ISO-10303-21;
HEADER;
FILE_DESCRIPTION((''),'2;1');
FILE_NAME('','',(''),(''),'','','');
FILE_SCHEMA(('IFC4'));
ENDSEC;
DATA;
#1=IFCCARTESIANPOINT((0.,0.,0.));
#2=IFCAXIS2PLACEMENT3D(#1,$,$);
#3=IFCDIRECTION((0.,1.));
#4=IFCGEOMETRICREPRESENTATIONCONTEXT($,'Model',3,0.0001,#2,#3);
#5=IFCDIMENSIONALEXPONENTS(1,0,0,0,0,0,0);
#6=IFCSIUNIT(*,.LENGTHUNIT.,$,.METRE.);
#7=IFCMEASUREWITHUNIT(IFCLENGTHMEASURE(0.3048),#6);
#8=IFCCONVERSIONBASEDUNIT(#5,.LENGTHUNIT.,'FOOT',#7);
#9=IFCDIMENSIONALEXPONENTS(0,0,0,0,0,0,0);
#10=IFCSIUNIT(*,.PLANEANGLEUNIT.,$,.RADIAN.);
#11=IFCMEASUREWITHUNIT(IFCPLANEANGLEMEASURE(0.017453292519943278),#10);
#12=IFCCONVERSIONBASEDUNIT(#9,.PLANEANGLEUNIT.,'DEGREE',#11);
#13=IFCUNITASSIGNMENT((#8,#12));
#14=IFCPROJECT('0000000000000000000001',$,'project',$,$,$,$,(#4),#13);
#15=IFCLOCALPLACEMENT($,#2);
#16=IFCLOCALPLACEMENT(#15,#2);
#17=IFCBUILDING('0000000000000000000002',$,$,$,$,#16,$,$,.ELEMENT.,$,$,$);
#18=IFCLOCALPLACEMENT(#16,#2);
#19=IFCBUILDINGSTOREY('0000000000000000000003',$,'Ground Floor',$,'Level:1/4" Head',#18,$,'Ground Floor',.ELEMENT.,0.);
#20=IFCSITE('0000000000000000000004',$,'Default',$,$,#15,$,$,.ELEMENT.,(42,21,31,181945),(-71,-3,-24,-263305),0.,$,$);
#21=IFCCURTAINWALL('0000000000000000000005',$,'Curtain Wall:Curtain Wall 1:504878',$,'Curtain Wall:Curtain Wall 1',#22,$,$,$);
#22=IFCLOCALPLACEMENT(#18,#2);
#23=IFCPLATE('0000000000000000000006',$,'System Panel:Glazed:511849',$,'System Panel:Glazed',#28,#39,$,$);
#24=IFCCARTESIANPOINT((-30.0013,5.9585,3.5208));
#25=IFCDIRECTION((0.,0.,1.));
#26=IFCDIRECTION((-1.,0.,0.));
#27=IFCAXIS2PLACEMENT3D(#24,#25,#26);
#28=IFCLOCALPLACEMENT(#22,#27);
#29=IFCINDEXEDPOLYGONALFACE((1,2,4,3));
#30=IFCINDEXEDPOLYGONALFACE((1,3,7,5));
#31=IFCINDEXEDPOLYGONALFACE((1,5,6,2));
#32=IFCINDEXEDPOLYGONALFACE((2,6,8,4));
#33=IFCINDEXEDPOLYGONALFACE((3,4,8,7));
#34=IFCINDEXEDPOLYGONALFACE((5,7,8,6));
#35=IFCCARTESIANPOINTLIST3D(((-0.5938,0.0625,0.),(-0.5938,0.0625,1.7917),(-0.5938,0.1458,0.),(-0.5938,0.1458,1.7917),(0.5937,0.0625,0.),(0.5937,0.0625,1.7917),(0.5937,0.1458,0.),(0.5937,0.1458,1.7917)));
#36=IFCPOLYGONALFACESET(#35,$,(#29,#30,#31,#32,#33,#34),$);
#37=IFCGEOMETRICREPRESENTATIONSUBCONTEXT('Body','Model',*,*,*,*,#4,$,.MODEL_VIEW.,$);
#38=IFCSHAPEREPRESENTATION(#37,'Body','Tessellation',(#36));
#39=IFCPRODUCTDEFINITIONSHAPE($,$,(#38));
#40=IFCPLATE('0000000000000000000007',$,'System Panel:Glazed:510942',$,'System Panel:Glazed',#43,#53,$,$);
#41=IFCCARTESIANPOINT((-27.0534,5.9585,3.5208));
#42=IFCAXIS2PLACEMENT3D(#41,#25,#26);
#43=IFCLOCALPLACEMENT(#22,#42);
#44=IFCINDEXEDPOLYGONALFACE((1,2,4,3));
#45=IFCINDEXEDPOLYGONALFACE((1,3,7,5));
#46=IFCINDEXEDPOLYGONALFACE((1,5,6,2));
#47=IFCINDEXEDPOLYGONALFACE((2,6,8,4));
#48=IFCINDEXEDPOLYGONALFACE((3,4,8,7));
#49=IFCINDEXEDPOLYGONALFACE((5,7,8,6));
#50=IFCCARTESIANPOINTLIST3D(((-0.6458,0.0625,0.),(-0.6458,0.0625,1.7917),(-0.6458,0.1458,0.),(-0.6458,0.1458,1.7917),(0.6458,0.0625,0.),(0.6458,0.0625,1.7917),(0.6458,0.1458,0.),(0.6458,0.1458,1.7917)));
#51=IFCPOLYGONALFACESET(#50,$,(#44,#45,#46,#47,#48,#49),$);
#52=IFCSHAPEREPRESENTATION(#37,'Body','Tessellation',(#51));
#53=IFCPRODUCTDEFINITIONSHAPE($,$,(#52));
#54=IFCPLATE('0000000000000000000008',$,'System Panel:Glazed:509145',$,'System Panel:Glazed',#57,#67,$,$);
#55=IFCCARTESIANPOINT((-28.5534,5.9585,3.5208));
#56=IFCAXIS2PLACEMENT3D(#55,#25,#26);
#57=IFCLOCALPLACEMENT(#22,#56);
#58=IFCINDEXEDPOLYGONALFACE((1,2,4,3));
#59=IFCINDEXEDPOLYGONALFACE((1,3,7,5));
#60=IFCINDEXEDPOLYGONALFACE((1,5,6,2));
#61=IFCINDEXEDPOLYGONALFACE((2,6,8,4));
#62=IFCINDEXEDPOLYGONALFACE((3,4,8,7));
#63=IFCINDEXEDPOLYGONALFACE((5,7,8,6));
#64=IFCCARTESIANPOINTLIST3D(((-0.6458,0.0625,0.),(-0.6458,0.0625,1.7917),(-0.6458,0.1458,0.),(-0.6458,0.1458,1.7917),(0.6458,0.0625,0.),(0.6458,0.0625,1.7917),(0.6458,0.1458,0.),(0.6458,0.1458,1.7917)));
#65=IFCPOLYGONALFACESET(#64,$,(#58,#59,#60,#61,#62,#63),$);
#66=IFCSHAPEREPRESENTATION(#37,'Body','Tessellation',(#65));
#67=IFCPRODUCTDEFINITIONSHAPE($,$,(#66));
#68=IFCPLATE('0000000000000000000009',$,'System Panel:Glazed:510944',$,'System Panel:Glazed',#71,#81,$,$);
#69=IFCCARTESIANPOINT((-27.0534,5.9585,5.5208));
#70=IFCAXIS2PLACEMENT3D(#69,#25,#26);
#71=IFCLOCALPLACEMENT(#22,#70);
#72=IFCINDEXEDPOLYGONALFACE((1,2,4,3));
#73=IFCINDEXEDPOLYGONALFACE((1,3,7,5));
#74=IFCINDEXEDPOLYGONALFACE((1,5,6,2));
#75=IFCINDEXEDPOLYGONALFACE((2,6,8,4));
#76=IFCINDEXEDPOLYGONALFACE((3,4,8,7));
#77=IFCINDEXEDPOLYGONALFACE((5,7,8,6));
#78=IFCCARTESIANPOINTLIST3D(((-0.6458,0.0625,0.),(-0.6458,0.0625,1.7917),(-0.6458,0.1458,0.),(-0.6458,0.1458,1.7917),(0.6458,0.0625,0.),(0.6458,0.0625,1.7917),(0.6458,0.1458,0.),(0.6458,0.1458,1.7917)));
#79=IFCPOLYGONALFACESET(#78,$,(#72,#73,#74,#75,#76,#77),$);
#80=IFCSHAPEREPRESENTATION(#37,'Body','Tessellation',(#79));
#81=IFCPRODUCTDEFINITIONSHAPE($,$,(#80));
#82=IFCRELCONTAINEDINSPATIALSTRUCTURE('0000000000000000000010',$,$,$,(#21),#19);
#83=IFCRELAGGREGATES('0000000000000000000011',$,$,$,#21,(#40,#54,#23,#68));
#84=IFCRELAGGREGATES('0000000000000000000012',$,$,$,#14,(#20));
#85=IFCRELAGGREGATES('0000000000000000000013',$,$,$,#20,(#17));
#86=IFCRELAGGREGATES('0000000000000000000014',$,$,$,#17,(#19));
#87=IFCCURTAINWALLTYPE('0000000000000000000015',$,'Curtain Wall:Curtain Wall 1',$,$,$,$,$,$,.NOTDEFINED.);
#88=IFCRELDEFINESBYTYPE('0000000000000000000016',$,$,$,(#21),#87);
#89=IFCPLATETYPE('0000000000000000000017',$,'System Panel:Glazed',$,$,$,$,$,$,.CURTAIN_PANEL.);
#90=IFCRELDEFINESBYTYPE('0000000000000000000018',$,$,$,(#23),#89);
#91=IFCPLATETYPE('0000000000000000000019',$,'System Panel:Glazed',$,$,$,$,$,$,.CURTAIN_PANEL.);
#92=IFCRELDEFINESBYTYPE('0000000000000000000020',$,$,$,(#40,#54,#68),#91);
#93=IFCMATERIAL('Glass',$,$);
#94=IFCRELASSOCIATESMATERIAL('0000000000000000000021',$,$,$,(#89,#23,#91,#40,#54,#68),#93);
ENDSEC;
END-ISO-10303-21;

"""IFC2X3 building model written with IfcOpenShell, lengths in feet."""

from ifc_helpers import new_model, entity, si_unit, converted_unit, direction, frame, frame_2d, origin, place, context, subcontext, project, spatial, rectangle, extrude, source, transform, mapped, material, type_object, type_shapes, element, aggregate, save


model = new_model("IFC2X3")

# Units and contexts
model_context = context("Model", 3, precision=0.0001, world=origin(), true_north=direction((0.0, 1.0)))
body_context = subcontext(model_context, "Body", "Model", "MODEL_VIEW")
ifc_project = project(units=[converted_unit("LENGTHUNIT", "FOOT", entity("IfcLengthMeasure", 0.3048), si_unit("LENGTHUNIT", "METRE"), dimensions=[1, 0, 0, 0, 0, 0, 0]), converted_unit("PLANEANGLEUNIT", "DEGREE", entity("IfcPlaneAngleMeasure", 0.017453292519943278), si_unit("PLANEANGLEUNIT", "RADIAN"), dimensions=[0, 0, 0, 0, 0, 0, 0])], contexts=[model_context])

# Site, building, storey
site_placement = place(None, origin())
site = spatial("IfcSite", under=ifc_project, at=site_placement, Name="Default", CompositionType="ELEMENT", RefLatitude=(42, 21, 31, 181945), RefLongitude=(-71, -3, -24, -263305), RefElevation=0.0)
building_placement = place(site_placement, origin())
building = spatial("IfcBuilding", under=site, at=building_placement, CompositionType="ELEMENT")
storey_placement = place(building_placement, origin())
storey = spatial("IfcBuildingStorey", under=building, at=storey_placement, Name="Ground Floor", ObjectType="Level:1/4\" Head", LongName="Ground Floor", CompositionType="ELEMENT", Elevation=0.0)

# Curtain wall, plates
curtain_wall_type = type_object("IfcCurtainWallType", Name="Curtain Wall:Curtain Wall 1", PredefinedType="NOTDEFINED")
curtain_wall_placement = place(storey_placement, origin())
curtain_wall = element("IfcCurtainWall", 1, at=curtain_wall_placement, inside=storey, type_object=curtain_wall_type, Name="Curtain Wall:Curtain Wall 1:504878", ObjectType="Curtain Wall:Curtain Wall 1")
ifc_material_1 = material(Name="Glass")
plate_type_1 = type_object("IfcPlateType", Name="System Panel:Glazed", PredefinedType="CURTAIN_PANEL", material=ifc_material_1)
shared_shape_1 = source(origin(), body_context, "Body", "SweptSolid", [
    extrude(rectangle(XDim=0.0833, YDim=1.1875, at=frame_2d((0.0, 0.0), x_axis=(1.0, 0.0))), frame((0.0, 0.1042, 0.0), z_axis=(0.0, 0.0, 1.0), x_axis=(0.0, 1.0, 0.0)), (0.0, 0.0, 1.0), 1.7917),
])
type_shapes(plate_type_1, [shared_shape_1])
plate_1_placement = place(curtain_wall_placement, frame((-30.0013, 5.9585, 3.5208), z_axis=(0.0, 0.0, 1.0), x_axis=(-1.0, 0.0, 0.0)))
plate_1 = element("IfcPlate", 2, at=plate_1_placement, type_object=plate_type_1, material=ifc_material_1, Name="System Panel:Glazed:511849", ObjectType="System Panel:Glazed", context=body_context, shape_type="MappedRepresentation", body=[
    mapped(shared_shape_1, transform((0.0, 0.0, 0.0), scale=1.0)),
])
plate_type_2 = type_object("IfcPlateType", Name="System Panel:Glazed", PredefinedType="CURTAIN_PANEL", material=ifc_material_1)
shared_shape_2 = source(origin(), body_context, "Body", "SweptSolid", [
    extrude(rectangle(XDim=0.0833, YDim=1.2917, at=frame_2d((0.0, 0.0), x_axis=(1.0, 0.0))), frame((0.0, 0.1042, 0.0), z_axis=(0.0, 0.0, 1.0), x_axis=(0.0, 1.0, 0.0)), (0.0, 0.0, 1.0), 1.7917),
])
type_shapes(plate_type_2, [shared_shape_2])
plate_2_placement = place(curtain_wall_placement, frame((-27.0534, 5.9585, 3.5208), z_axis=(0.0, 0.0, 1.0), x_axis=(-1.0, 0.0, 0.0)))
plate_2 = element("IfcPlate", 3, at=plate_2_placement, type_object=plate_type_2, material=ifc_material_1, Name="System Panel:Glazed:510942", ObjectType="System Panel:Glazed", context=body_context, shape_type="MappedRepresentation", body=[
    mapped(shared_shape_2, transform((0.0, 0.0, 0.0), scale=1.0)),
])
plate_3_placement = place(curtain_wall_placement, frame((-28.5534, 5.9585, 3.5208), z_axis=(0.0, 0.0, 1.0), x_axis=(-1.0, 0.0, 0.0)))
plate_3 = element("IfcPlate", 4, at=plate_3_placement, type_object=plate_type_2, material=ifc_material_1, Name="System Panel:Glazed:509145", ObjectType="System Panel:Glazed", context=body_context, shape_type="MappedRepresentation", body=[
    mapped(shared_shape_2, transform((0.0, 0.0, 0.0), scale=1.0)),
])
plate_4_placement = place(curtain_wall_placement, frame((-27.0534, 5.9585, 5.5208), z_axis=(0.0, 0.0, 1.0), x_axis=(-1.0, 0.0, 0.0)))
plate_4 = element("IfcPlate", 5, at=plate_4_placement, type_object=plate_type_2, material=ifc_material_1, Name="System Panel:Glazed:510944", ObjectType="System Panel:Glazed", context=body_context, shape_type="MappedRepresentation", body=[
    mapped(shared_shape_2, transform((0.0, 0.0, 0.0), scale=1.0)),
])
aggregate(curtain_wall, [plate_2, plate_3, plate_1, plate_4])

save(model, "model.ifc")
